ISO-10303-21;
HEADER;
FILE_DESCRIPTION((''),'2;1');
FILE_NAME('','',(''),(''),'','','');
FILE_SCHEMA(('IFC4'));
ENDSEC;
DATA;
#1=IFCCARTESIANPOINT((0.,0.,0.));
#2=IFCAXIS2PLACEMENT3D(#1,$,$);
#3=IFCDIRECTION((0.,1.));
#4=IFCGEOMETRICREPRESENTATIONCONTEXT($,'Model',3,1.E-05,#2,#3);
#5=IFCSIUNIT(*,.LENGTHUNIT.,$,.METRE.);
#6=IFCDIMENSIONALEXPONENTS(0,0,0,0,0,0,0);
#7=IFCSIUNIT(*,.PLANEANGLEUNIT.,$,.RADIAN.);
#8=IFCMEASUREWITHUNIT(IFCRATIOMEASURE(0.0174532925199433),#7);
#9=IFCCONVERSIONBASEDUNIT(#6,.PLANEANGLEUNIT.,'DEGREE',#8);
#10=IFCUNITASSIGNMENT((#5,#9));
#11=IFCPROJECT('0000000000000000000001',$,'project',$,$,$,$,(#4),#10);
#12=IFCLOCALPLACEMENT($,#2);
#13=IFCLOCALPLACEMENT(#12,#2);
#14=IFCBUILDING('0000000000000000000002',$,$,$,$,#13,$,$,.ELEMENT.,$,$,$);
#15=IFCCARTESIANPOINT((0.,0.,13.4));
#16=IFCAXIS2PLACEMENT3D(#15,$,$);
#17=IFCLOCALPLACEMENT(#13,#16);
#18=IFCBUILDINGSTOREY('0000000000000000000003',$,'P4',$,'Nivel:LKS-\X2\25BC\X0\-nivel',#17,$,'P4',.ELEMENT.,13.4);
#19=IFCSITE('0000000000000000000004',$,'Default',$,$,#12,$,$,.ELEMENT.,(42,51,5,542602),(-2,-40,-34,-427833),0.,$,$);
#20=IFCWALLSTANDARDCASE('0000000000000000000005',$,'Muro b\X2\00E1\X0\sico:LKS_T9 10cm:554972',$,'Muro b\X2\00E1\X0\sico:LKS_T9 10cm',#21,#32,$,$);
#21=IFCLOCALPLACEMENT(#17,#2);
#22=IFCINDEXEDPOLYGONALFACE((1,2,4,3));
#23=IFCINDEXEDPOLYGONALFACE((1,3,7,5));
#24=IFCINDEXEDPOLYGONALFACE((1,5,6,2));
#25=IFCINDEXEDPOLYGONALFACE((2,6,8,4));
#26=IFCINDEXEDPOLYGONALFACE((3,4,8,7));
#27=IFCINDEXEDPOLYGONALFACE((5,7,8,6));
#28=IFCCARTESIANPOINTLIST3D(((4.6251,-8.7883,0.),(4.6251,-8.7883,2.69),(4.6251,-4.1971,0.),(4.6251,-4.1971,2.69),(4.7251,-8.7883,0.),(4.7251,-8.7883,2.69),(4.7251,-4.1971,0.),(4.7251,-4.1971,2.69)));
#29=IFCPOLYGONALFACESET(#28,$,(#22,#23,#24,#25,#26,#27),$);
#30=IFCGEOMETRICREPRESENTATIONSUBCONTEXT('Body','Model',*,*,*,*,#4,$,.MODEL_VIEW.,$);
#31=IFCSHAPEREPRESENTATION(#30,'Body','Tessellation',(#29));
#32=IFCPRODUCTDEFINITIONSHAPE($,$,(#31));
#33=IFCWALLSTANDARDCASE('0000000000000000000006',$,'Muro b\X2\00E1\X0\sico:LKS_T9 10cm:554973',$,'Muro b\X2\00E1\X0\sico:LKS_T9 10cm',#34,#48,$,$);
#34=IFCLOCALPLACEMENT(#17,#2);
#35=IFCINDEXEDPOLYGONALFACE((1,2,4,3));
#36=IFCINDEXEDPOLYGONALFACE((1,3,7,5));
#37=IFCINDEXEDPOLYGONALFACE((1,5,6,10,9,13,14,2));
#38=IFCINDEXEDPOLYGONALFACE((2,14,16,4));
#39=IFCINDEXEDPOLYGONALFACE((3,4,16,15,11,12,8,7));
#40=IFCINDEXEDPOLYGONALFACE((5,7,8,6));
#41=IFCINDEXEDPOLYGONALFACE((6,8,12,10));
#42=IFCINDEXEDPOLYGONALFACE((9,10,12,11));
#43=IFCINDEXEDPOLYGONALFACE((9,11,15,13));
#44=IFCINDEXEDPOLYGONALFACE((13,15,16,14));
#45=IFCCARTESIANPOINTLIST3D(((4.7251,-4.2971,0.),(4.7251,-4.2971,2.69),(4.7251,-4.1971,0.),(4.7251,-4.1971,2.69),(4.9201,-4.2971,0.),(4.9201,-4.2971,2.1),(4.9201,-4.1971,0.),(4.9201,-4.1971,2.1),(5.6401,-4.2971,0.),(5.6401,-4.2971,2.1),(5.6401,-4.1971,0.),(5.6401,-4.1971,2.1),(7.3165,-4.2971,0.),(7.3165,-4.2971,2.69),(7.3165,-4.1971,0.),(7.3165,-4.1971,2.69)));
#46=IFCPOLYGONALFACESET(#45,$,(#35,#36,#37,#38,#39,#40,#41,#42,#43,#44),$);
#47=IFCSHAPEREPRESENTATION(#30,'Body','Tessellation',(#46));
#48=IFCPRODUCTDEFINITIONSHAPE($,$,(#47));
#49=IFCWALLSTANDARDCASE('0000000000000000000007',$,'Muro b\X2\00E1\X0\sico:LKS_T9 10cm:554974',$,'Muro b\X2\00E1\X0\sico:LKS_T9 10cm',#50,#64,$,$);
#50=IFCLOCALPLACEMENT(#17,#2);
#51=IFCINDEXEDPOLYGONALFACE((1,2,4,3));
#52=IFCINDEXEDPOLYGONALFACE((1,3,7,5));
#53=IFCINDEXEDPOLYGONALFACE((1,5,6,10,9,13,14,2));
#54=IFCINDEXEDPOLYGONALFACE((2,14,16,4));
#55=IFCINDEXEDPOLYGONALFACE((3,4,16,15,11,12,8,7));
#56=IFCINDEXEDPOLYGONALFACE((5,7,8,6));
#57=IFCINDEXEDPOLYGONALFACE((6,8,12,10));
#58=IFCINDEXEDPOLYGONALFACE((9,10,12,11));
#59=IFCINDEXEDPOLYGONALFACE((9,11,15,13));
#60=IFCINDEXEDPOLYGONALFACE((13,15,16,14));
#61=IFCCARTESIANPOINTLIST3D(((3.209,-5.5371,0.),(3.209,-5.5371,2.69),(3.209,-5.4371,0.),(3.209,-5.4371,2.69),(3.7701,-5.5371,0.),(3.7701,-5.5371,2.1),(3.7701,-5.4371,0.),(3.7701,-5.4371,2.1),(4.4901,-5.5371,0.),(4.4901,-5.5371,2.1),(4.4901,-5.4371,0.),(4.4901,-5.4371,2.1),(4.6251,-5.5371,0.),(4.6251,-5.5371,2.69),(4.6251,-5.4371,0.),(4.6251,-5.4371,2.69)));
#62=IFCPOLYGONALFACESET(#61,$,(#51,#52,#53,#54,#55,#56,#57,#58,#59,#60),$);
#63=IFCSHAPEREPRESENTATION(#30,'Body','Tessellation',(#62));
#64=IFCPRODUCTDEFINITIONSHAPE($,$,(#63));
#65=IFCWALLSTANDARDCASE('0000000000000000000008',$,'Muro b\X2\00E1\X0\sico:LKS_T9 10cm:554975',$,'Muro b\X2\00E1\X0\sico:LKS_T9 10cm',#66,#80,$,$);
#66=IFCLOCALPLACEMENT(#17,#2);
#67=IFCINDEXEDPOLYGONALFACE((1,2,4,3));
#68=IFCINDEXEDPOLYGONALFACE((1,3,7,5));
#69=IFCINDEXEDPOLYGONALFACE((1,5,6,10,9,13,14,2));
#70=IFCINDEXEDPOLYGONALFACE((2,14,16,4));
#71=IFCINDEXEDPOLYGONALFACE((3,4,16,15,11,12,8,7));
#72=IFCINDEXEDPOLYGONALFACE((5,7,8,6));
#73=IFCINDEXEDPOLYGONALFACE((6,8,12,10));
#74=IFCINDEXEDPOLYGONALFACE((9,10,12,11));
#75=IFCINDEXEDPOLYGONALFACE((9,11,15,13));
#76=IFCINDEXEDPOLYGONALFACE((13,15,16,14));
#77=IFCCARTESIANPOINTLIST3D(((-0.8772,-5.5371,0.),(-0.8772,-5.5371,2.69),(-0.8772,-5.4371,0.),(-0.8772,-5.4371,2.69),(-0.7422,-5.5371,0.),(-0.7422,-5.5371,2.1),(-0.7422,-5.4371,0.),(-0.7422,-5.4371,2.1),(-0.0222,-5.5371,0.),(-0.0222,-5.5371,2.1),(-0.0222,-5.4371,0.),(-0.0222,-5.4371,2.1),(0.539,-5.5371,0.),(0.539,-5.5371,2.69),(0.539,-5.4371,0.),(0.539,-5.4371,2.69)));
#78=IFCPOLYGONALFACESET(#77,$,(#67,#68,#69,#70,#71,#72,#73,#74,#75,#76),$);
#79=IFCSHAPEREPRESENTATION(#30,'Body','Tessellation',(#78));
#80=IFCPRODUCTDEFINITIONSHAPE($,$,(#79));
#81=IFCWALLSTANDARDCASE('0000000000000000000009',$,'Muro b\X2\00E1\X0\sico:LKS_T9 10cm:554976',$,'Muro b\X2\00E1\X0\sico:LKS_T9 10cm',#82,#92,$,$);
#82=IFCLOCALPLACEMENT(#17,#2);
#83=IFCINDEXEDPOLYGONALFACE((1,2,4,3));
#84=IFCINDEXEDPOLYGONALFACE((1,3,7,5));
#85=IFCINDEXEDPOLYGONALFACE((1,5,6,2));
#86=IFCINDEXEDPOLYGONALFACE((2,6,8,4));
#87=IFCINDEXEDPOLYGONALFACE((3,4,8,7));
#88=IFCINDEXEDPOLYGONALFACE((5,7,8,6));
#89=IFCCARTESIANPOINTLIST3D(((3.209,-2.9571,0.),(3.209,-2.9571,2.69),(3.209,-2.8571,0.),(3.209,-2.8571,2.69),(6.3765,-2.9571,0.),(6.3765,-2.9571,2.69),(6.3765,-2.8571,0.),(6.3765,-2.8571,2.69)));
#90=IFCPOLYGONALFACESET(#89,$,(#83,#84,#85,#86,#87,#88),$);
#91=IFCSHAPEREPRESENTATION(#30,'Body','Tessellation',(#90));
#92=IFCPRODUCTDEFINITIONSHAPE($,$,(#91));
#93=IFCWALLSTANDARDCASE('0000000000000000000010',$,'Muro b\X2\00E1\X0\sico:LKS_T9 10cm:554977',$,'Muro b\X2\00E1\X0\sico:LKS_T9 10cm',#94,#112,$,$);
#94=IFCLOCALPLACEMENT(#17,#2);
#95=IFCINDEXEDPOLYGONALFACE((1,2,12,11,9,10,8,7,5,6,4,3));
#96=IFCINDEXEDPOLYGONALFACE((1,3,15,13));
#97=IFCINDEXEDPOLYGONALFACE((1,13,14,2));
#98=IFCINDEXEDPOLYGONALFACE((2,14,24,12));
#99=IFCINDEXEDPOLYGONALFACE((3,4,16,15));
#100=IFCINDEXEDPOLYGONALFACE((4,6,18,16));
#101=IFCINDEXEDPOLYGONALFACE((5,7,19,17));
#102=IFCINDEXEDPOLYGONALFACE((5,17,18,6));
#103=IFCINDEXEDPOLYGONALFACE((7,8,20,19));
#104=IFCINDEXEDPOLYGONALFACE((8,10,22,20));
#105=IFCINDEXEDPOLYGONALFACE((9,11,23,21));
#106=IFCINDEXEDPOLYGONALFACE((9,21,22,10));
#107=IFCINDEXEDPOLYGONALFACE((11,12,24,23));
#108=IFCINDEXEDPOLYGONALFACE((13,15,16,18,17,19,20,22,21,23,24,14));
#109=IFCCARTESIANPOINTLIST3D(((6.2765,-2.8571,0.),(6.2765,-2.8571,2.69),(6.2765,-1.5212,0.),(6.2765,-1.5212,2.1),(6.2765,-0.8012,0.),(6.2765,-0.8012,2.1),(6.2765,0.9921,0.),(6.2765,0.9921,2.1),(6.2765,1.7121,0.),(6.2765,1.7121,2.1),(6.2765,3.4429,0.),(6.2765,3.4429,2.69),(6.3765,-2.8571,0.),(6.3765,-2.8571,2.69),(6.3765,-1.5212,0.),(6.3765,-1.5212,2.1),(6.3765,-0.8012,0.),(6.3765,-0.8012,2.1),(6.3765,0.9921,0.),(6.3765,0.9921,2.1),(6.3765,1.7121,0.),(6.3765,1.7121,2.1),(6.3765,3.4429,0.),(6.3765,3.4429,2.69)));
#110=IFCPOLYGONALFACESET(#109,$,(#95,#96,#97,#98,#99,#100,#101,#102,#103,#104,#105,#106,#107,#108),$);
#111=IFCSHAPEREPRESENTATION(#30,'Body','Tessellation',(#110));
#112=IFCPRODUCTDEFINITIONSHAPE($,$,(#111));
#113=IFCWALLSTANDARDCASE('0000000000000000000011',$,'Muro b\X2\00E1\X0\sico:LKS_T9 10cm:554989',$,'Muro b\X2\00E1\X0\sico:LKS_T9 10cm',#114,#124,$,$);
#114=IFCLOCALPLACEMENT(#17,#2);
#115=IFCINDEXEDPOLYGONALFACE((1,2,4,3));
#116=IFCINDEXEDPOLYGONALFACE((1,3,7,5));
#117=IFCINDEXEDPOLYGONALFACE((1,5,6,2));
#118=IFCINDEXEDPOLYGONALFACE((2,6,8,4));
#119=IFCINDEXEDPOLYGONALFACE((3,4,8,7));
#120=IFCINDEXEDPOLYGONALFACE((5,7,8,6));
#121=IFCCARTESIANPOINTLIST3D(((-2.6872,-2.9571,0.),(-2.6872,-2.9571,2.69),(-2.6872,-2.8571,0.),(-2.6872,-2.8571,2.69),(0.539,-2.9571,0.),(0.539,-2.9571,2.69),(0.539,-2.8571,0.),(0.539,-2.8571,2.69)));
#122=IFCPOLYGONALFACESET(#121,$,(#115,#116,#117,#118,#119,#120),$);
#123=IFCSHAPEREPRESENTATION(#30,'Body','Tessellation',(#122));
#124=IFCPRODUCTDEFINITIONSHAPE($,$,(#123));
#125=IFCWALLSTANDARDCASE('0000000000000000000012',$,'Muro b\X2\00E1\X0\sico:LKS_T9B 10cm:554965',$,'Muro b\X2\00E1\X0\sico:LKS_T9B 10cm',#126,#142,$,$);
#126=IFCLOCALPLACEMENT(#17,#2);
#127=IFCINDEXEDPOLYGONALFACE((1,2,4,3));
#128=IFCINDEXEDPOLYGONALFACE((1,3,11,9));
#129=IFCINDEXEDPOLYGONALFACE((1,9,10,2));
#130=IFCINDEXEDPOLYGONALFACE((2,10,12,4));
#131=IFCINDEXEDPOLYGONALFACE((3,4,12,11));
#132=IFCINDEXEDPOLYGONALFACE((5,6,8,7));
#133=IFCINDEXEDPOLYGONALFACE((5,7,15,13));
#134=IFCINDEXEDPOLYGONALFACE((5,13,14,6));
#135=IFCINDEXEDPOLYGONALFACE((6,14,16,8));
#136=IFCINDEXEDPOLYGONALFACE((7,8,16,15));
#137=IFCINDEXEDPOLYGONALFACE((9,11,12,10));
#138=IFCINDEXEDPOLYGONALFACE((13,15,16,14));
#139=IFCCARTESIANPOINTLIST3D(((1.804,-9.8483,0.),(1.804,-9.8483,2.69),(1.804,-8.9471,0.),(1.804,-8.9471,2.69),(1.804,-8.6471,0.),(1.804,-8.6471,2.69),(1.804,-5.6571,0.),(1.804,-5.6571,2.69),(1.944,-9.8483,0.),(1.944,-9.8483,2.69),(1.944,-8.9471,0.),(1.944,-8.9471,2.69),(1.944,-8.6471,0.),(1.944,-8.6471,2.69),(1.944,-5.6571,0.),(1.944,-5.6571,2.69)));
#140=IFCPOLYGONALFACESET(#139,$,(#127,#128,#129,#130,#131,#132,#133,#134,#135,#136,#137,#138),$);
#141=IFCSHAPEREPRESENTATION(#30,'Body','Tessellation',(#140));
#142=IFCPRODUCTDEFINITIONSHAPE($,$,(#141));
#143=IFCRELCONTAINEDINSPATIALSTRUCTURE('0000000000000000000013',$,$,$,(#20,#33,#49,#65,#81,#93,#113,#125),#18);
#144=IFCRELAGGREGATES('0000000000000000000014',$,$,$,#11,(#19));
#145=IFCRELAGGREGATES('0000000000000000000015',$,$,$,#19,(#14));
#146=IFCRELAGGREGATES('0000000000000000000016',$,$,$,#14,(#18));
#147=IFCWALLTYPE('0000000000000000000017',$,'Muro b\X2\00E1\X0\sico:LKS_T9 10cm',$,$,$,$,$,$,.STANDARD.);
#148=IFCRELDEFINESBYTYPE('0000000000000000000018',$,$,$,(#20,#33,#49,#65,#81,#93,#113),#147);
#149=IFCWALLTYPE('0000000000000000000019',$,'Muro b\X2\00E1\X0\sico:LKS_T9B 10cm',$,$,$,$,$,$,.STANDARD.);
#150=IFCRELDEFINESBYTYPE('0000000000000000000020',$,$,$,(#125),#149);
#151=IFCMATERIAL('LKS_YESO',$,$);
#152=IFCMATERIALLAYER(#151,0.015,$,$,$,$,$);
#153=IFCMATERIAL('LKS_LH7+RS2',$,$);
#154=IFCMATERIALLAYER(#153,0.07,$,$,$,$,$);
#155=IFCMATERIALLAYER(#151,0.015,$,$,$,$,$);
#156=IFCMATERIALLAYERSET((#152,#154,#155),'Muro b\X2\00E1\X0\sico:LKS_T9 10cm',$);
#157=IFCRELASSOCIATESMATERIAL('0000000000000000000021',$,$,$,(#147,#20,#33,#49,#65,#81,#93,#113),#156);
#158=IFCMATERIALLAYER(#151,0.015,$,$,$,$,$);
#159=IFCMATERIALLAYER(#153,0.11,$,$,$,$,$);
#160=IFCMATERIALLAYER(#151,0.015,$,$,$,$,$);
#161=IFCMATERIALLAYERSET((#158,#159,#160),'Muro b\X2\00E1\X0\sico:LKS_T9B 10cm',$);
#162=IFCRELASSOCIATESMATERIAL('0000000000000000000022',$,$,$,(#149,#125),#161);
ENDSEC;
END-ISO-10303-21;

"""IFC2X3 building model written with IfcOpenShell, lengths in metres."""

from ifc_helpers import new_model, entity, si_unit, converted_unit, direction, frame, frame_2d, origin, origin_2d_with_axis, place, context, subcontext, project, spatial, polyline, rectangle, extrude, clip, bounded_halfspace, material, layer, layer_set, layer_usage, type_object, element, save


model = new_model("IFC2X3")

# Units and contexts
model_context = context("Model", 3, precision=1e-05, world=origin(), true_north=direction((0.0, 1.0)))
body_context = subcontext(model_context, "Body", "Model", "MODEL_VIEW")
ifc_project = project(units=[si_unit("LENGTHUNIT", "METRE"), converted_unit("PLANEANGLEUNIT", "DEGREE", entity("IfcRatioMeasure", 0.0174532925199433), si_unit("PLANEANGLEUNIT", "RADIAN"), dimensions=[0, 0, 0, 0, 0, 0, 0])], contexts=[model_context])

# Site, building, storey
site_placement = place(None, origin())
site = spatial("IfcSite", under=ifc_project, at=site_placement, Name="Default", CompositionType="ELEMENT", RefLatitude=(42, 51, 5, 542602), RefLongitude=(-2, -40, -34, -427833), RefElevation=0.0)
building_placement = place(site_placement, origin())
building = spatial("IfcBuilding", under=site, at=building_placement, CompositionType="ELEMENT")
storey_placement = place(building_placement, frame((0.0, 0.0, 13.4)))
storey = spatial("IfcBuildingStorey", under=building, at=storey_placement, Name="P4", ObjectType="Nivel:LKS-▼-nivel", LongName="P4", CompositionType="ELEMENT", Elevation=13.4)

# Shared definitions
ifc_material_1 = material(Name="LKS_LH7+RS2")
ifc_material_2 = material(Name="LKS_YESO")

# Shared definitions
ifc_layer_1 = layer(ifc_material_2, 0.015)
ifc_layer_2 = layer(ifc_material_1, 0.07)
ifc_layer_3 = layer(ifc_material_2, 0.015)
ifc_layer_set_1 = layer_set([ifc_layer_1, ifc_layer_2, ifc_layer_3], Name="Muro básico:LKS_T9 10cm")
wall_type_1 = type_object("IfcWallType", Name="Muro básico:LKS_T9 10cm", PredefinedType="STANDARD", material=ifc_layer_set_1)

# Wall
ifc_layer_usage_1 = layer_usage(ifc_layer_set_1, "AXIS2", "NEGATIVE", 0.05)
wall_1_placement = place(storey_placement, frame((4.6751, -8.7883, 0.0), z_axis=(0.0, 0.0, 1.0), x_axis=(0.0, 1.0, 0.0)))
element("IfcWallStandardCase", 1, at=wall_1_placement, inside=storey, type_object=wall_type_1, material=ifc_layer_usage_1, Name="Muro básico:LKS_T9 10cm:554972", ObjectType="Muro básico:LKS_T9 10cm", context=body_context, shape_type="SweptSolid", body=[
    extrude(rectangle(XDim=4.5911, YDim=0.1, at=frame_2d((2.2956, 0.0), x_axis=(-1.0, 0.0))), origin(), (0.0, 0.0, 1.0), 2.69),
])

# Walls, openings
ifc_layer_usage_2 = layer_usage(ifc_layer_set_1, "AXIS2", "NEGATIVE", 0.05)
wall_2_placement = place(storey_placement, frame((4.7251, -4.2471, 0.0)))
wall_2 = element("IfcWallStandardCase", 2, at=wall_2_placement, inside=storey, type_object=wall_type_1, material=ifc_layer_usage_2, Name="Muro básico:LKS_T9 10cm:554973", ObjectType="Muro básico:LKS_T9 10cm", context=body_context, shape_type="Clipping", body=[
    clip(extrude(rectangle(XDim=2.5915, YDim=0.1, at=frame_2d((1.2957, 0.0), x_axis=(-1.0, 0.0))), origin(), (0.0, 0.0, 1.0), 2.69), bounded_halfspace(frame((2.5915, -0.05, 2.69), z_axis=(-1.0, 0.0, 0.0), x_axis=(0.0, 0.0, -1.0)), True, frame((2.5915, -0.05, 2.69), z_axis=(-1.0, 0.0, 0.0), x_axis=(0.0, 0.0, -1.0)), polyline([(0.0, 0.0), (0.0, -0.1), (2.69, -0.1), (2.69, 0.0), (0.0, 0.0)]))),
])
opening_1_placement = place(wall_2_placement, frame((0.915, 0.05, 0.0)))
element("IfcOpeningElement", 3, at=opening_1_placement, cuts=wall_2, ObjectType="Opening", context=body_context, shape_type="SweptSolid", body=[
    extrude(rectangle(XDim=2.1, YDim=0.72, at=frame_2d((1.05, 0.36), x_axis=(1.0, 0.0))), frame((0.0, 0.0, 0.0), z_axis=(0.0, -1.0, 0.0), x_axis=(0.0, 0.0, 1.0)), (0.0, 0.0, 1.0), 0.1),
])
ifc_layer_usage_3 = layer_usage(ifc_layer_set_1, "AXIS2", "POSITIVE", -0.05)
wall_3_placement = place(storey_placement, frame((3.209, -5.4871, 0.0)))
wall_3 = element("IfcWallStandardCase", 4, at=wall_3_placement, inside=storey, type_object=wall_type_1, material=ifc_layer_usage_3, Name="Muro básico:LKS_T9 10cm:554974", ObjectType="Muro básico:LKS_T9 10cm", context=body_context, shape_type="SweptSolid", body=[
    extrude(rectangle(XDim=1.4161, YDim=0.1, at=frame_2d((0.7081, 0.0), x_axis=(-1.0, 0.0))), origin(), (0.0, 0.0, 1.0), 2.69),
])
opening_2_placement = place(wall_3_placement, frame((1.2811, 0.05, 0.0)))
element("IfcOpeningElement", 5, at=opening_2_placement, cuts=wall_3, ObjectType="Opening", context=body_context, shape_type="SweptSolid", body=[
    extrude(rectangle(XDim=2.1, YDim=0.72, at=frame_2d((1.05, 0.36), x_axis=(1.0, 0.0))), frame((0.0, 0.0, 0.0), z_axis=(0.0, -1.0, 0.0), x_axis=(0.0, 0.0, 1.0)), (0.0, 0.0, 1.0), 0.1),
])
ifc_layer_usage_4 = layer_usage(ifc_layer_set_1, "AXIS2", "NEGATIVE", 0.05)
wall_4_placement = place(storey_placement, frame((0.539, -5.4871, 0.0), z_axis=(0.0, 0.0, 1.0), x_axis=(-1.0, 0.0, 0.0)))
wall_4 = element("IfcWallStandardCase", 6, at=wall_4_placement, inside=storey, type_object=wall_type_1, material=ifc_layer_usage_4, Name="Muro básico:LKS_T9 10cm:554975", ObjectType="Muro básico:LKS_T9 10cm", context=body_context, shape_type="SweptSolid", body=[
    extrude(rectangle(XDim=1.4161, YDim=0.1, at=frame_2d((0.7081, 0.0), x_axis=(-1.0, 0.0))), origin(), (0.0, 0.0, 1.0), 2.69),
])
opening_3_placement = place(wall_4_placement, frame((0.5611, -0.05, 0.0)))
element("IfcOpeningElement", 7, at=opening_3_placement, cuts=wall_4, ObjectType="Opening", context=body_context, shape_type="SweptSolid", body=[
    extrude(rectangle(XDim=2.1, YDim=0.72, at=frame_2d((1.05, 0.36), x_axis=(1.0, 0.0))), frame((0.0, 0.0, 0.0), z_axis=(0.0, 1.0, 0.0), x_axis=(0.0, 0.0, 1.0)), (0.0, 0.0, 1.0), 0.1),
])

# Wall
ifc_layer_usage_5 = layer_usage(ifc_layer_set_1, "AXIS2", "NEGATIVE", 0.05)
wall_5_placement = place(storey_placement, frame((3.209, -2.9071, 0.0)))
element("IfcWallStandardCase", 8, at=wall_5_placement, inside=storey, type_object=wall_type_1, material=ifc_layer_usage_5, Name="Muro básico:LKS_T9 10cm:554976", ObjectType="Muro básico:LKS_T9 10cm", context=body_context, shape_type="SweptSolid", body=[
    extrude(rectangle(XDim=3.1676, YDim=0.1, at=frame_2d((1.5838, 0.0), x_axis=(-1.0, 0.0))), origin(), (0.0, 0.0, 1.0), 2.69),
])

# Wall, openings
ifc_layer_usage_6 = layer_usage(ifc_layer_set_1, "AXIS2", "NEGATIVE", 0.05)
wall_6_placement = place(storey_placement, frame((6.3265, -2.8571, 0.0), z_axis=(0.0, 0.0, 1.0), x_axis=(0.0, 1.0, 0.0)))
wall_6 = element("IfcWallStandardCase", 9, at=wall_6_placement, inside=storey, type_object=wall_type_1, material=ifc_layer_usage_6, Name="Muro básico:LKS_T9 10cm:554977", ObjectType="Muro básico:LKS_T9 10cm", context=body_context, shape_type="SweptSolid", body=[
    extrude(rectangle(XDim=6.3, YDim=0.1, at=frame_2d((3.15, 0.0), x_axis=(-1.0, 0.0))), origin(), (0.0, 0.0, 1.0), 2.69),
])
opening_4_placement = place(wall_6_placement, frame((1.3359, -0.05, 0.0)))
element("IfcOpeningElement", 10, at=opening_4_placement, cuts=wall_6, ObjectType="Opening", context=body_context, shape_type="SweptSolid", body=[
    extrude(rectangle(XDim=2.1, YDim=0.72, at=frame_2d((1.05, 0.36), x_axis=(1.0, 0.0))), frame((0.0, 0.0, 0.0), z_axis=(0.0, 1.0, 0.0), x_axis=(0.0, 0.0, 1.0)), (0.0, 0.0, 1.0), 0.1),
])
opening_5_placement = place(wall_6_placement, frame((3.8492, -0.05, 0.0)))
element("IfcOpeningElement", 11, at=opening_5_placement, cuts=wall_6, ObjectType="Opening", context=body_context, shape_type="SweptSolid", body=[
    extrude(rectangle(XDim=2.1, YDim=0.72, at=frame_2d((1.05, 0.36), x_axis=(1.0, 0.0))), frame((0.0, 0.0, 0.0), z_axis=(0.0, 1.0, 0.0), x_axis=(0.0, 0.0, 1.0)), (0.0, 0.0, 1.0), 0.1),
])

# Wall
ifc_layer_usage_7 = layer_usage(ifc_layer_set_1, "AXIS2", "NEGATIVE", 0.05)
wall_7_placement = place(storey_placement, frame((-2.6872, -2.9071, 0.0)))
element("IfcWallStandardCase", 12, at=wall_7_placement, inside=storey, type_object=wall_type_1, material=ifc_layer_usage_7, Name="Muro básico:LKS_T9 10cm:554989", ObjectType="Muro básico:LKS_T9 10cm", context=body_context, shape_type="SweptSolid", body=[
    extrude(rectangle(XDim=3.2261, YDim=0.1, at=frame_2d((1.6131, 0.0), x_axis=(-1.0, 0.0))), origin(), (0.0, 0.0, 1.0), 2.69),
])

# Wall, opening
ifc_layer_4 = layer(ifc_material_2, 0.015)
ifc_layer_5 = layer(ifc_material_1, 0.11)
ifc_layer_6 = layer(ifc_material_2, 0.015)
ifc_layer_set_2 = layer_set([ifc_layer_4, ifc_layer_5, ifc_layer_6], Name="Muro básico:LKS_T9B 10cm")
ifc_layer_usage_8 = layer_usage(ifc_layer_set_2, "AXIS2", "NEGATIVE", 0.07)
wall_type_2 = type_object("IfcWallType", Name="Muro básico:LKS_T9B 10cm", PredefinedType="STANDARD", material=ifc_layer_set_2)
wall_8_placement = place(storey_placement, frame((1.874, -5.6571, 0.0), z_axis=(0.0, 0.0, 1.0), x_axis=(0.0, -1.0, 0.0)))
wall_8 = element("IfcWallStandardCase", 13, at=wall_8_placement, inside=storey, type_object=wall_type_2, material=ifc_layer_usage_8, Name="Muro básico:LKS_T9B 10cm:554965", ObjectType="Muro básico:LKS_T9B 10cm", context=body_context, shape_type="SweptSolid", body=[
    extrude(rectangle(XDim=4.1911, YDim=0.14, at=frame_2d((2.0956, 0.0), x_axis=(-1.0, 0.0))), origin(), (0.0, 0.0, 1.0), 2.69),
])
opening_6_placement = place(storey_placement, frame((1.874, -5.6571, 0.0), z_axis=(0.0, 0.0, 1.0), x_axis=(0.0, -1.0, 0.0)))
element("IfcOpeningElement", 14, at=opening_6_placement, cuts=wall_8, ObjectType="Opening", context=body_context, shape_type="SweptSolid", body=[
    extrude(rectangle(XDim=2.69, YDim=0.14, at=origin_2d_with_axis()), frame((3.29, 0.0, 1.345), z_axis=(-1.0, 0.0, 0.0), x_axis=(0.0, 0.0, 1.0)), (0.0, 0.0, 1.0), 0.3),
])

save(model, "model.ifc")
